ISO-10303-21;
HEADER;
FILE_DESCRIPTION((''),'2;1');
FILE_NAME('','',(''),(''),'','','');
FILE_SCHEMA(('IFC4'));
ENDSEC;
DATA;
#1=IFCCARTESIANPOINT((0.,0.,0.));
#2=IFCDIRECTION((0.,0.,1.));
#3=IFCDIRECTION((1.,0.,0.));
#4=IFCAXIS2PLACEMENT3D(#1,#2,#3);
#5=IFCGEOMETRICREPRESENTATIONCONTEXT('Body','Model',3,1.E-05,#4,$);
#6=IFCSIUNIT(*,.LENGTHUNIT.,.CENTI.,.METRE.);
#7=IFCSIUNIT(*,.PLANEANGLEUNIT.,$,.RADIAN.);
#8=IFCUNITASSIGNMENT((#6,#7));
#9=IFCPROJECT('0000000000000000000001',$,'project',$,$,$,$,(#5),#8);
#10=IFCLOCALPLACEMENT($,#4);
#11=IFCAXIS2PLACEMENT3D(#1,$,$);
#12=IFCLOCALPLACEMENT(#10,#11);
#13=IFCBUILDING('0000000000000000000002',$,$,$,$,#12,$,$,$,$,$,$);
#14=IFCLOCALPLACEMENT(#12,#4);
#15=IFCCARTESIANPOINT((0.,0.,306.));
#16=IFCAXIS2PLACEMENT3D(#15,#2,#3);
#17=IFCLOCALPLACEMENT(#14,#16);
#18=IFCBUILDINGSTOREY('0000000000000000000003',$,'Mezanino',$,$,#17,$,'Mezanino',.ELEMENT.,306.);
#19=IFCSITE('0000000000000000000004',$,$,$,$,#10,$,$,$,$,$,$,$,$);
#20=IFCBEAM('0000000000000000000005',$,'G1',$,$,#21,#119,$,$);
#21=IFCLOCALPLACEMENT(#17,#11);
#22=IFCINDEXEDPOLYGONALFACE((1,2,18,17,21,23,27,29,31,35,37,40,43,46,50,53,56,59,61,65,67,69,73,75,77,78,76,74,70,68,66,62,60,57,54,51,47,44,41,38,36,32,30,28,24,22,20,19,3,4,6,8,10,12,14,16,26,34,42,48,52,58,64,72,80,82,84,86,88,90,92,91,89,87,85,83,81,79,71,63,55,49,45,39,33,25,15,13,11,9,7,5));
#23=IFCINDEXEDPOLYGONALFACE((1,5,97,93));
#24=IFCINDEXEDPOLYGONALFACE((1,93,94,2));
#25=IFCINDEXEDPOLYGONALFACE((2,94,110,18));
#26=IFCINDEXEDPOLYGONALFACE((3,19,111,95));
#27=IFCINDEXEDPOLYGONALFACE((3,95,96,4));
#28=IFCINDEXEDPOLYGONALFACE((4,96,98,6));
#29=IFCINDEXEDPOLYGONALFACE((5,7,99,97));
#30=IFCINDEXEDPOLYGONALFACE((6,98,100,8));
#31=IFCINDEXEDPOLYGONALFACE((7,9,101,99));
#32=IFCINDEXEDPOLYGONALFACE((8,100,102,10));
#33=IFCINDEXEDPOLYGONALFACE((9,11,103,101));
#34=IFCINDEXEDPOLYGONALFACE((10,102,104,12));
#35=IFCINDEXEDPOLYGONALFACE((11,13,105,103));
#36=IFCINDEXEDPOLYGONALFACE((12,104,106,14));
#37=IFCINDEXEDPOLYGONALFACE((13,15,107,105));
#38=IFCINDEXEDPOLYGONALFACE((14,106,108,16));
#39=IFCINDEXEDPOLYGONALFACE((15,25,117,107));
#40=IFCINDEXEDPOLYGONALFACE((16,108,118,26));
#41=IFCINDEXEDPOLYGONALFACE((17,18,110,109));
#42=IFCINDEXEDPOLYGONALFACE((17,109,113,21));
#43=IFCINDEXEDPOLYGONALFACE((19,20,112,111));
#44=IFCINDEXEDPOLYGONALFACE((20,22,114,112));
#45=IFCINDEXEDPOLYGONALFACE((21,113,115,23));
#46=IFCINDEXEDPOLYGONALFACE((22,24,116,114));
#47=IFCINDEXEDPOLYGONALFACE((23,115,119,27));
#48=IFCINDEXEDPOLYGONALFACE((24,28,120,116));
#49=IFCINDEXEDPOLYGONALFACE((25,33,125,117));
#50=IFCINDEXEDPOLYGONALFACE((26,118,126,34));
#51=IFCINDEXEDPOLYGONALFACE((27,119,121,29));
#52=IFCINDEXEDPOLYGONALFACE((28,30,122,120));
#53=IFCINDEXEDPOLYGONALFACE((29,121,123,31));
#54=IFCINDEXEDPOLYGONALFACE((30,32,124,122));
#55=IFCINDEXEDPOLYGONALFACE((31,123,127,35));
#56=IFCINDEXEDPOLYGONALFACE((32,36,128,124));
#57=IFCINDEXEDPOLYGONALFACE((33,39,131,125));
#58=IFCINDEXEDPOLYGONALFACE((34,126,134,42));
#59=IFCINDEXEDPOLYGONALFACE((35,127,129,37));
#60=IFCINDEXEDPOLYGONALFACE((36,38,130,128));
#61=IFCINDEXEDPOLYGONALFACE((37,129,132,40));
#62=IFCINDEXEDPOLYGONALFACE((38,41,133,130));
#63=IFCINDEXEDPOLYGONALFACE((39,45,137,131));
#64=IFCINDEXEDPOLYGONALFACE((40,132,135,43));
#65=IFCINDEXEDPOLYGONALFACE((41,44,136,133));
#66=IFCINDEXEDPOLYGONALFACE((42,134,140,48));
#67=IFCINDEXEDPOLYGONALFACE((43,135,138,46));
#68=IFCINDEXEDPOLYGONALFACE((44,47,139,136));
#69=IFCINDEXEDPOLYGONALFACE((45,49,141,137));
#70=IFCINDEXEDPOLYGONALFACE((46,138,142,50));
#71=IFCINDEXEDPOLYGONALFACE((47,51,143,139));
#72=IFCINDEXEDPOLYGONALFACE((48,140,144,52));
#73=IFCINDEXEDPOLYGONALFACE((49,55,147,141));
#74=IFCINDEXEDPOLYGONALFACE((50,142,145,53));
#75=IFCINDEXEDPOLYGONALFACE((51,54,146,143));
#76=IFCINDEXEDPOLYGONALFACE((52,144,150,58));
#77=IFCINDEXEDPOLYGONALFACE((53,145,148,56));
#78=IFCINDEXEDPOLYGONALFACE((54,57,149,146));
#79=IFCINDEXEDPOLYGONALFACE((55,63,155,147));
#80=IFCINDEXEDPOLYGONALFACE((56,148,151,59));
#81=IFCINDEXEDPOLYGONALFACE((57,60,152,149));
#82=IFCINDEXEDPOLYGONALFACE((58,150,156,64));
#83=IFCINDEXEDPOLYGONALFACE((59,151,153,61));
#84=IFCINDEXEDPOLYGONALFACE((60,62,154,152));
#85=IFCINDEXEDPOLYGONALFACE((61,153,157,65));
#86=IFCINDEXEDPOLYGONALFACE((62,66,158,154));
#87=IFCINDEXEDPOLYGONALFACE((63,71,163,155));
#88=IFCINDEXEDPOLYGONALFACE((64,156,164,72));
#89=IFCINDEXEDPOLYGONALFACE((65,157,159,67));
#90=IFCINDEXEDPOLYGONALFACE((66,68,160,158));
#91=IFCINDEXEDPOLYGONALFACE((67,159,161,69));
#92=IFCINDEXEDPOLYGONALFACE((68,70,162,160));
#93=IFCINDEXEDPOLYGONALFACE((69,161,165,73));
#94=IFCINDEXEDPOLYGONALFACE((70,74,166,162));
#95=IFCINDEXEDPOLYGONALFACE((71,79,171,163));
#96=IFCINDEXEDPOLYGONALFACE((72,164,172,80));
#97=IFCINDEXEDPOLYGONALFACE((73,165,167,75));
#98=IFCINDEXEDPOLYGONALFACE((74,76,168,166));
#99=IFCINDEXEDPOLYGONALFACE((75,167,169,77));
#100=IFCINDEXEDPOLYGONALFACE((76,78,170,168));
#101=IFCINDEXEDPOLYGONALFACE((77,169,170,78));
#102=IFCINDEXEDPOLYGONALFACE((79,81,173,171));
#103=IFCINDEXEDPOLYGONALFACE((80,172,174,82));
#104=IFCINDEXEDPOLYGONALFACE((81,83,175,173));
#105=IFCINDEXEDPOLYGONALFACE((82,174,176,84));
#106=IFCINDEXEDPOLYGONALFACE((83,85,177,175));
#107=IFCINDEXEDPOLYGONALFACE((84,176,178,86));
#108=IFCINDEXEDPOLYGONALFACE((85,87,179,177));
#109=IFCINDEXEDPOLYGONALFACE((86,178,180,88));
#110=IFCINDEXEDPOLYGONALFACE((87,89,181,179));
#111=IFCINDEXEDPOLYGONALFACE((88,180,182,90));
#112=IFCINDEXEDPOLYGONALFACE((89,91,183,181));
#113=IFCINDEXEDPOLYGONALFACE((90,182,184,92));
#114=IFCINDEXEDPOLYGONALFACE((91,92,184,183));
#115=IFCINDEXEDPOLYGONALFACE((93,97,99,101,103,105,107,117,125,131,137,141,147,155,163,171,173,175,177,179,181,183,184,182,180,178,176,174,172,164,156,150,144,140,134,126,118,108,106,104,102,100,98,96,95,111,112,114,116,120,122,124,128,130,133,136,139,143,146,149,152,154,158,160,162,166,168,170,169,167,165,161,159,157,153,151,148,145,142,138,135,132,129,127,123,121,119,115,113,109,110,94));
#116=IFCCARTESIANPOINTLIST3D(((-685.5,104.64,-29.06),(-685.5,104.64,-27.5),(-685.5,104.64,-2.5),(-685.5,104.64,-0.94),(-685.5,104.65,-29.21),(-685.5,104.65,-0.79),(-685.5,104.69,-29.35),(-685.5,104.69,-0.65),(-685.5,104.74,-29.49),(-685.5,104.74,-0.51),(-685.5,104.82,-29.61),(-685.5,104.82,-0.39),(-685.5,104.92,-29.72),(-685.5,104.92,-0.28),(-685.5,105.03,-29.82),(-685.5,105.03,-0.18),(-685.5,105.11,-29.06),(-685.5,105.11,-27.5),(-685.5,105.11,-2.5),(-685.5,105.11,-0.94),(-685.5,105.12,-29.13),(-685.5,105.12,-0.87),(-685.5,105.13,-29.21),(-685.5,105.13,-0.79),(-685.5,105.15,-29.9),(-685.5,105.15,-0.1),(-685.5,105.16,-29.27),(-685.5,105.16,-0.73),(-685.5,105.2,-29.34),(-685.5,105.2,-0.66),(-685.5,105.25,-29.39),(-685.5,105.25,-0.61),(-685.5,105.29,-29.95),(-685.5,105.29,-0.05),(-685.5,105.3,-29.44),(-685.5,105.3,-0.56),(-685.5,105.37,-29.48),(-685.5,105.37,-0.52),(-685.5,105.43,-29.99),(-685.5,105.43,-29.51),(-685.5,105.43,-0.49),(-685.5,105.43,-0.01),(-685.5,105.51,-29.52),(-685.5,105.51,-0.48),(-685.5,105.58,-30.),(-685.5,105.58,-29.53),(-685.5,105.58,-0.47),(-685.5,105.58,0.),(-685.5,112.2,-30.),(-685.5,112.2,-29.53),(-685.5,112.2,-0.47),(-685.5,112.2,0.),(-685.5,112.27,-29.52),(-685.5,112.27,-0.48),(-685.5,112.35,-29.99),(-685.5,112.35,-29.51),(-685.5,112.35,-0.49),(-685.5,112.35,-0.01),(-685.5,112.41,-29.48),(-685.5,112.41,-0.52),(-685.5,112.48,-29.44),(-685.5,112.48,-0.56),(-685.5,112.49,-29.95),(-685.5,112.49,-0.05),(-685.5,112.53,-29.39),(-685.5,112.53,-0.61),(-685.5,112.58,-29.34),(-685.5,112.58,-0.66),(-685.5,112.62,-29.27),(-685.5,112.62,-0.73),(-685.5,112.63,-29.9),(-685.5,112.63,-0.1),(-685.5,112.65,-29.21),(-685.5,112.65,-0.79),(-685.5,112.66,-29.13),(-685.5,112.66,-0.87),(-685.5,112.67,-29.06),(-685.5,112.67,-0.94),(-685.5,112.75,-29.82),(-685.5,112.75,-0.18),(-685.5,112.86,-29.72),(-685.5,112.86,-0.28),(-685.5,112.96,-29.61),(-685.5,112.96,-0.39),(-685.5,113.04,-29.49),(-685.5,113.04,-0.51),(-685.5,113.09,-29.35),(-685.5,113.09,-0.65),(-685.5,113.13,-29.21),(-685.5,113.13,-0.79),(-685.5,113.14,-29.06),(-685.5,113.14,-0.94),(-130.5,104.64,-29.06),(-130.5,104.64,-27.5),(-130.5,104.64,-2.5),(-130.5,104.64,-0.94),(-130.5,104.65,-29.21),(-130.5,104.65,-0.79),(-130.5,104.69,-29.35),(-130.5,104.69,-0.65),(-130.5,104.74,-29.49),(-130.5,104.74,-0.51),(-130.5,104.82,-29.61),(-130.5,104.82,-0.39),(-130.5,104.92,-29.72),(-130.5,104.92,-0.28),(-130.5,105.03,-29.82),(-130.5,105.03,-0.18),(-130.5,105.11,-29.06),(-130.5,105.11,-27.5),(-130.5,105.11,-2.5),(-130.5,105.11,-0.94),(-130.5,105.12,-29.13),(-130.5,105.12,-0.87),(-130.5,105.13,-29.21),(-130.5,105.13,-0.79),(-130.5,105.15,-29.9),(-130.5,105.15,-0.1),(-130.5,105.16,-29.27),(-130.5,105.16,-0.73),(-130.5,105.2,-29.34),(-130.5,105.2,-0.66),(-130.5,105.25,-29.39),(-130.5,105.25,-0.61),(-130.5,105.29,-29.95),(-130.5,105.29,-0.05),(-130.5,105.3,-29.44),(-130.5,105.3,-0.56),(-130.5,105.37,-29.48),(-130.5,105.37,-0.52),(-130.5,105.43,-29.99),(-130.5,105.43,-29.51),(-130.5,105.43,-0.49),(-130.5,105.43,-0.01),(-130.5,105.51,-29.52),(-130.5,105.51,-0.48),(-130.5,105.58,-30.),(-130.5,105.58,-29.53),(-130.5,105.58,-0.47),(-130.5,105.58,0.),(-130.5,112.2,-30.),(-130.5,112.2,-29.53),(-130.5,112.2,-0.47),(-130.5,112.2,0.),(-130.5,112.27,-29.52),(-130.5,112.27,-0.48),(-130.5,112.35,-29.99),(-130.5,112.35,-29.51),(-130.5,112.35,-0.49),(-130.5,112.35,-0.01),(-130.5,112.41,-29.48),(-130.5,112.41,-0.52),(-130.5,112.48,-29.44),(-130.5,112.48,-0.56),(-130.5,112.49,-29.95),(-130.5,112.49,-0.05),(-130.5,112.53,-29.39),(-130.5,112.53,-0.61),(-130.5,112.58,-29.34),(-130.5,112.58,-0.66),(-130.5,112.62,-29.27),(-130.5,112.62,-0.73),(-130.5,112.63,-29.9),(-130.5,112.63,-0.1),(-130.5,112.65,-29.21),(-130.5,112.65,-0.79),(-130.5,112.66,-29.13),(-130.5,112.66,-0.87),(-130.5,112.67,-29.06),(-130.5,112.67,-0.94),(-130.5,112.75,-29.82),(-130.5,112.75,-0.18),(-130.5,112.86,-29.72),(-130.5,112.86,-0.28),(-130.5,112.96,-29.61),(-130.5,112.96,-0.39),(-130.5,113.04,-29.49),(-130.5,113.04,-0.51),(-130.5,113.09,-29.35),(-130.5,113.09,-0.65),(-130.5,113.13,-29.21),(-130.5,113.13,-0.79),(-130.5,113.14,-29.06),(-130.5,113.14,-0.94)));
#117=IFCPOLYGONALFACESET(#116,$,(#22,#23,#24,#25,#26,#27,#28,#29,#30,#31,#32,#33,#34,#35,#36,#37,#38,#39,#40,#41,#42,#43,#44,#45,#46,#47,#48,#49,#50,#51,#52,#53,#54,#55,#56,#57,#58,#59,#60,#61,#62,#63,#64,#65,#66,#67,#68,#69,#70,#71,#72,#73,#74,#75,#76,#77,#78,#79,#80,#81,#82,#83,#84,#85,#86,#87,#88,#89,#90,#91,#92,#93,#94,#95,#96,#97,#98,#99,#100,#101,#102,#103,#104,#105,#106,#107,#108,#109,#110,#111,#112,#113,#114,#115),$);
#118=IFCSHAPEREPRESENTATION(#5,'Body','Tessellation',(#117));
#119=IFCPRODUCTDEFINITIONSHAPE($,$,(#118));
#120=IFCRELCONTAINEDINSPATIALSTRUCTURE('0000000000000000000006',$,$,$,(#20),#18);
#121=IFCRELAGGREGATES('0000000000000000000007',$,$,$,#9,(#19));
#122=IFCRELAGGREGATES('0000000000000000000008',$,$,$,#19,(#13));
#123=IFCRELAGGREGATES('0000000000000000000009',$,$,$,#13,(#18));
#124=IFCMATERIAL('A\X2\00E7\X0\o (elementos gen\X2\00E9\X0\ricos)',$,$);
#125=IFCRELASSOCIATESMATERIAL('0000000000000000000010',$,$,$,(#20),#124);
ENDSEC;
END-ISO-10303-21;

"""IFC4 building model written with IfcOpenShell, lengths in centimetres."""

from ifc_helpers import new_model, si_unit, frame, origin, origin_with_axes, place, context, project, spatial, polyline, outline, extrude, material, element, save


model = new_model("IFC4")

# Units and contexts
model_context = context("Model", 3, precision=1e-05, world=origin_with_axes(), identifier="Body")
ifc_project = project(units=[si_unit("LENGTHUNIT", "METRE", prefix="CENTI"), si_unit("PLANEANGLEUNIT", "RADIAN")], contexts=[model_context])

# Site, building, storey
site_placement = place(None, origin_with_axes())
site = spatial("IfcSite", under=ifc_project, at=site_placement)
building_placement = place(site_placement, origin())
building = spatial("IfcBuilding", under=site, at=building_placement)
placement = place(building_placement, origin_with_axes())
storey_placement = place(placement, frame((0.0, 0.0, 306.0), z_axis=(0.0, 0.0, 1.0), x_axis=(1.0, 0.0, 0.0)))
storey = spatial("IfcBuildingStorey", under=building, at=storey_placement, Name="Mezanino", LongName="Mezanino", CompositionType="ELEMENT", Elevation=306.0)

# Beam
ifc_material_1 = material(Name="Aço (elementos genéricos)")
beam_1_placement = place(storey_placement, frame((-408.0, 108.89, 0.0), z_axis=(0.0, 0.0, 1.0), x_axis=(1.0, 0.0, 0.0)))
element("IfcBeam", 1, at=beam_1_placement, inside=storey, material=ifc_material_1, Name="G1", context=model_context, shape_type="SolidModel", body=[
    extrude(outline(polyline([(-4.25, -14.06), (-4.24, -14.21), (-4.2, -14.35), (-4.15, -14.49), (-4.07, -14.61), (-3.97, -14.72), (-3.86, -14.82), (-3.74, -14.9), (-3.6, -14.95), (-3.46, -14.99), (-3.31, -15.0), (3.31, -15.0), (3.46, -14.99), (3.6, -14.95), (3.74, -14.9), (3.86, -14.82), (3.97, -14.72), (4.07, -14.61), (4.15, -14.49), (4.2, -14.35), (4.24, -14.21), (4.25, -14.06), (4.25, -12.5), (3.78, -12.5), (3.78, -14.06), (3.77, -14.13), (3.76, -14.21), (3.73, -14.27), (3.69, -14.34), (3.64, -14.39), (3.59, -14.44), (3.52, -14.48), (3.46, -14.51), (3.38, -14.52), (3.31, -14.53), (-3.31, -14.53), (-3.38, -14.52), (-3.46, -14.51), (-3.52, -14.48), (-3.59, -14.44), (-3.64, -14.39), (-3.69, -14.34), (-3.73, -14.27), (-3.76, -14.21), (-3.77, -14.13), (-3.78, -14.06), (-3.78, 14.06), (-3.77, 14.13), (-3.76, 14.21), (-3.73, 14.27), (-3.69, 14.34), (-3.64, 14.39), (-3.59, 14.44), (-3.52, 14.48), (-3.46, 14.51), (-3.38, 14.52), (-3.31, 14.53), (3.31, 14.53), (3.38, 14.52), (3.46, 14.51), (3.52, 14.48), (3.59, 14.44), (3.64, 14.39), (3.69, 14.34), (3.73, 14.27), (3.76, 14.21), (3.77, 14.13), (3.78, 14.06), (3.78, 12.5), (4.25, 12.5), (4.25, 14.06), (4.24, 14.21), (4.2, 14.35), (4.15, 14.49), (4.07, 14.61), (3.97, 14.72), (3.86, 14.82), (3.74, 14.9), (3.6, 14.95), (3.46, 14.99), (3.31, 15.0), (-3.31, 15.0), (-3.46, 14.99), (-3.6, 14.95), (-3.74, 14.9), (-3.86, 14.82), (-3.97, 14.72), (-4.07, 14.61), (-4.15, 14.49), (-4.2, 14.35), (-4.24, 14.21), (-4.25, 14.06), (-4.25, -14.06)])), frame((-277.5, 0.0, -15.0), z_axis=(1.0, 0.0, 0.0), x_axis=(0.0, -1.0, 0.0)), (0.0, 0.0, 1.0), 555.0),
])

save(model, "model.ifc")
